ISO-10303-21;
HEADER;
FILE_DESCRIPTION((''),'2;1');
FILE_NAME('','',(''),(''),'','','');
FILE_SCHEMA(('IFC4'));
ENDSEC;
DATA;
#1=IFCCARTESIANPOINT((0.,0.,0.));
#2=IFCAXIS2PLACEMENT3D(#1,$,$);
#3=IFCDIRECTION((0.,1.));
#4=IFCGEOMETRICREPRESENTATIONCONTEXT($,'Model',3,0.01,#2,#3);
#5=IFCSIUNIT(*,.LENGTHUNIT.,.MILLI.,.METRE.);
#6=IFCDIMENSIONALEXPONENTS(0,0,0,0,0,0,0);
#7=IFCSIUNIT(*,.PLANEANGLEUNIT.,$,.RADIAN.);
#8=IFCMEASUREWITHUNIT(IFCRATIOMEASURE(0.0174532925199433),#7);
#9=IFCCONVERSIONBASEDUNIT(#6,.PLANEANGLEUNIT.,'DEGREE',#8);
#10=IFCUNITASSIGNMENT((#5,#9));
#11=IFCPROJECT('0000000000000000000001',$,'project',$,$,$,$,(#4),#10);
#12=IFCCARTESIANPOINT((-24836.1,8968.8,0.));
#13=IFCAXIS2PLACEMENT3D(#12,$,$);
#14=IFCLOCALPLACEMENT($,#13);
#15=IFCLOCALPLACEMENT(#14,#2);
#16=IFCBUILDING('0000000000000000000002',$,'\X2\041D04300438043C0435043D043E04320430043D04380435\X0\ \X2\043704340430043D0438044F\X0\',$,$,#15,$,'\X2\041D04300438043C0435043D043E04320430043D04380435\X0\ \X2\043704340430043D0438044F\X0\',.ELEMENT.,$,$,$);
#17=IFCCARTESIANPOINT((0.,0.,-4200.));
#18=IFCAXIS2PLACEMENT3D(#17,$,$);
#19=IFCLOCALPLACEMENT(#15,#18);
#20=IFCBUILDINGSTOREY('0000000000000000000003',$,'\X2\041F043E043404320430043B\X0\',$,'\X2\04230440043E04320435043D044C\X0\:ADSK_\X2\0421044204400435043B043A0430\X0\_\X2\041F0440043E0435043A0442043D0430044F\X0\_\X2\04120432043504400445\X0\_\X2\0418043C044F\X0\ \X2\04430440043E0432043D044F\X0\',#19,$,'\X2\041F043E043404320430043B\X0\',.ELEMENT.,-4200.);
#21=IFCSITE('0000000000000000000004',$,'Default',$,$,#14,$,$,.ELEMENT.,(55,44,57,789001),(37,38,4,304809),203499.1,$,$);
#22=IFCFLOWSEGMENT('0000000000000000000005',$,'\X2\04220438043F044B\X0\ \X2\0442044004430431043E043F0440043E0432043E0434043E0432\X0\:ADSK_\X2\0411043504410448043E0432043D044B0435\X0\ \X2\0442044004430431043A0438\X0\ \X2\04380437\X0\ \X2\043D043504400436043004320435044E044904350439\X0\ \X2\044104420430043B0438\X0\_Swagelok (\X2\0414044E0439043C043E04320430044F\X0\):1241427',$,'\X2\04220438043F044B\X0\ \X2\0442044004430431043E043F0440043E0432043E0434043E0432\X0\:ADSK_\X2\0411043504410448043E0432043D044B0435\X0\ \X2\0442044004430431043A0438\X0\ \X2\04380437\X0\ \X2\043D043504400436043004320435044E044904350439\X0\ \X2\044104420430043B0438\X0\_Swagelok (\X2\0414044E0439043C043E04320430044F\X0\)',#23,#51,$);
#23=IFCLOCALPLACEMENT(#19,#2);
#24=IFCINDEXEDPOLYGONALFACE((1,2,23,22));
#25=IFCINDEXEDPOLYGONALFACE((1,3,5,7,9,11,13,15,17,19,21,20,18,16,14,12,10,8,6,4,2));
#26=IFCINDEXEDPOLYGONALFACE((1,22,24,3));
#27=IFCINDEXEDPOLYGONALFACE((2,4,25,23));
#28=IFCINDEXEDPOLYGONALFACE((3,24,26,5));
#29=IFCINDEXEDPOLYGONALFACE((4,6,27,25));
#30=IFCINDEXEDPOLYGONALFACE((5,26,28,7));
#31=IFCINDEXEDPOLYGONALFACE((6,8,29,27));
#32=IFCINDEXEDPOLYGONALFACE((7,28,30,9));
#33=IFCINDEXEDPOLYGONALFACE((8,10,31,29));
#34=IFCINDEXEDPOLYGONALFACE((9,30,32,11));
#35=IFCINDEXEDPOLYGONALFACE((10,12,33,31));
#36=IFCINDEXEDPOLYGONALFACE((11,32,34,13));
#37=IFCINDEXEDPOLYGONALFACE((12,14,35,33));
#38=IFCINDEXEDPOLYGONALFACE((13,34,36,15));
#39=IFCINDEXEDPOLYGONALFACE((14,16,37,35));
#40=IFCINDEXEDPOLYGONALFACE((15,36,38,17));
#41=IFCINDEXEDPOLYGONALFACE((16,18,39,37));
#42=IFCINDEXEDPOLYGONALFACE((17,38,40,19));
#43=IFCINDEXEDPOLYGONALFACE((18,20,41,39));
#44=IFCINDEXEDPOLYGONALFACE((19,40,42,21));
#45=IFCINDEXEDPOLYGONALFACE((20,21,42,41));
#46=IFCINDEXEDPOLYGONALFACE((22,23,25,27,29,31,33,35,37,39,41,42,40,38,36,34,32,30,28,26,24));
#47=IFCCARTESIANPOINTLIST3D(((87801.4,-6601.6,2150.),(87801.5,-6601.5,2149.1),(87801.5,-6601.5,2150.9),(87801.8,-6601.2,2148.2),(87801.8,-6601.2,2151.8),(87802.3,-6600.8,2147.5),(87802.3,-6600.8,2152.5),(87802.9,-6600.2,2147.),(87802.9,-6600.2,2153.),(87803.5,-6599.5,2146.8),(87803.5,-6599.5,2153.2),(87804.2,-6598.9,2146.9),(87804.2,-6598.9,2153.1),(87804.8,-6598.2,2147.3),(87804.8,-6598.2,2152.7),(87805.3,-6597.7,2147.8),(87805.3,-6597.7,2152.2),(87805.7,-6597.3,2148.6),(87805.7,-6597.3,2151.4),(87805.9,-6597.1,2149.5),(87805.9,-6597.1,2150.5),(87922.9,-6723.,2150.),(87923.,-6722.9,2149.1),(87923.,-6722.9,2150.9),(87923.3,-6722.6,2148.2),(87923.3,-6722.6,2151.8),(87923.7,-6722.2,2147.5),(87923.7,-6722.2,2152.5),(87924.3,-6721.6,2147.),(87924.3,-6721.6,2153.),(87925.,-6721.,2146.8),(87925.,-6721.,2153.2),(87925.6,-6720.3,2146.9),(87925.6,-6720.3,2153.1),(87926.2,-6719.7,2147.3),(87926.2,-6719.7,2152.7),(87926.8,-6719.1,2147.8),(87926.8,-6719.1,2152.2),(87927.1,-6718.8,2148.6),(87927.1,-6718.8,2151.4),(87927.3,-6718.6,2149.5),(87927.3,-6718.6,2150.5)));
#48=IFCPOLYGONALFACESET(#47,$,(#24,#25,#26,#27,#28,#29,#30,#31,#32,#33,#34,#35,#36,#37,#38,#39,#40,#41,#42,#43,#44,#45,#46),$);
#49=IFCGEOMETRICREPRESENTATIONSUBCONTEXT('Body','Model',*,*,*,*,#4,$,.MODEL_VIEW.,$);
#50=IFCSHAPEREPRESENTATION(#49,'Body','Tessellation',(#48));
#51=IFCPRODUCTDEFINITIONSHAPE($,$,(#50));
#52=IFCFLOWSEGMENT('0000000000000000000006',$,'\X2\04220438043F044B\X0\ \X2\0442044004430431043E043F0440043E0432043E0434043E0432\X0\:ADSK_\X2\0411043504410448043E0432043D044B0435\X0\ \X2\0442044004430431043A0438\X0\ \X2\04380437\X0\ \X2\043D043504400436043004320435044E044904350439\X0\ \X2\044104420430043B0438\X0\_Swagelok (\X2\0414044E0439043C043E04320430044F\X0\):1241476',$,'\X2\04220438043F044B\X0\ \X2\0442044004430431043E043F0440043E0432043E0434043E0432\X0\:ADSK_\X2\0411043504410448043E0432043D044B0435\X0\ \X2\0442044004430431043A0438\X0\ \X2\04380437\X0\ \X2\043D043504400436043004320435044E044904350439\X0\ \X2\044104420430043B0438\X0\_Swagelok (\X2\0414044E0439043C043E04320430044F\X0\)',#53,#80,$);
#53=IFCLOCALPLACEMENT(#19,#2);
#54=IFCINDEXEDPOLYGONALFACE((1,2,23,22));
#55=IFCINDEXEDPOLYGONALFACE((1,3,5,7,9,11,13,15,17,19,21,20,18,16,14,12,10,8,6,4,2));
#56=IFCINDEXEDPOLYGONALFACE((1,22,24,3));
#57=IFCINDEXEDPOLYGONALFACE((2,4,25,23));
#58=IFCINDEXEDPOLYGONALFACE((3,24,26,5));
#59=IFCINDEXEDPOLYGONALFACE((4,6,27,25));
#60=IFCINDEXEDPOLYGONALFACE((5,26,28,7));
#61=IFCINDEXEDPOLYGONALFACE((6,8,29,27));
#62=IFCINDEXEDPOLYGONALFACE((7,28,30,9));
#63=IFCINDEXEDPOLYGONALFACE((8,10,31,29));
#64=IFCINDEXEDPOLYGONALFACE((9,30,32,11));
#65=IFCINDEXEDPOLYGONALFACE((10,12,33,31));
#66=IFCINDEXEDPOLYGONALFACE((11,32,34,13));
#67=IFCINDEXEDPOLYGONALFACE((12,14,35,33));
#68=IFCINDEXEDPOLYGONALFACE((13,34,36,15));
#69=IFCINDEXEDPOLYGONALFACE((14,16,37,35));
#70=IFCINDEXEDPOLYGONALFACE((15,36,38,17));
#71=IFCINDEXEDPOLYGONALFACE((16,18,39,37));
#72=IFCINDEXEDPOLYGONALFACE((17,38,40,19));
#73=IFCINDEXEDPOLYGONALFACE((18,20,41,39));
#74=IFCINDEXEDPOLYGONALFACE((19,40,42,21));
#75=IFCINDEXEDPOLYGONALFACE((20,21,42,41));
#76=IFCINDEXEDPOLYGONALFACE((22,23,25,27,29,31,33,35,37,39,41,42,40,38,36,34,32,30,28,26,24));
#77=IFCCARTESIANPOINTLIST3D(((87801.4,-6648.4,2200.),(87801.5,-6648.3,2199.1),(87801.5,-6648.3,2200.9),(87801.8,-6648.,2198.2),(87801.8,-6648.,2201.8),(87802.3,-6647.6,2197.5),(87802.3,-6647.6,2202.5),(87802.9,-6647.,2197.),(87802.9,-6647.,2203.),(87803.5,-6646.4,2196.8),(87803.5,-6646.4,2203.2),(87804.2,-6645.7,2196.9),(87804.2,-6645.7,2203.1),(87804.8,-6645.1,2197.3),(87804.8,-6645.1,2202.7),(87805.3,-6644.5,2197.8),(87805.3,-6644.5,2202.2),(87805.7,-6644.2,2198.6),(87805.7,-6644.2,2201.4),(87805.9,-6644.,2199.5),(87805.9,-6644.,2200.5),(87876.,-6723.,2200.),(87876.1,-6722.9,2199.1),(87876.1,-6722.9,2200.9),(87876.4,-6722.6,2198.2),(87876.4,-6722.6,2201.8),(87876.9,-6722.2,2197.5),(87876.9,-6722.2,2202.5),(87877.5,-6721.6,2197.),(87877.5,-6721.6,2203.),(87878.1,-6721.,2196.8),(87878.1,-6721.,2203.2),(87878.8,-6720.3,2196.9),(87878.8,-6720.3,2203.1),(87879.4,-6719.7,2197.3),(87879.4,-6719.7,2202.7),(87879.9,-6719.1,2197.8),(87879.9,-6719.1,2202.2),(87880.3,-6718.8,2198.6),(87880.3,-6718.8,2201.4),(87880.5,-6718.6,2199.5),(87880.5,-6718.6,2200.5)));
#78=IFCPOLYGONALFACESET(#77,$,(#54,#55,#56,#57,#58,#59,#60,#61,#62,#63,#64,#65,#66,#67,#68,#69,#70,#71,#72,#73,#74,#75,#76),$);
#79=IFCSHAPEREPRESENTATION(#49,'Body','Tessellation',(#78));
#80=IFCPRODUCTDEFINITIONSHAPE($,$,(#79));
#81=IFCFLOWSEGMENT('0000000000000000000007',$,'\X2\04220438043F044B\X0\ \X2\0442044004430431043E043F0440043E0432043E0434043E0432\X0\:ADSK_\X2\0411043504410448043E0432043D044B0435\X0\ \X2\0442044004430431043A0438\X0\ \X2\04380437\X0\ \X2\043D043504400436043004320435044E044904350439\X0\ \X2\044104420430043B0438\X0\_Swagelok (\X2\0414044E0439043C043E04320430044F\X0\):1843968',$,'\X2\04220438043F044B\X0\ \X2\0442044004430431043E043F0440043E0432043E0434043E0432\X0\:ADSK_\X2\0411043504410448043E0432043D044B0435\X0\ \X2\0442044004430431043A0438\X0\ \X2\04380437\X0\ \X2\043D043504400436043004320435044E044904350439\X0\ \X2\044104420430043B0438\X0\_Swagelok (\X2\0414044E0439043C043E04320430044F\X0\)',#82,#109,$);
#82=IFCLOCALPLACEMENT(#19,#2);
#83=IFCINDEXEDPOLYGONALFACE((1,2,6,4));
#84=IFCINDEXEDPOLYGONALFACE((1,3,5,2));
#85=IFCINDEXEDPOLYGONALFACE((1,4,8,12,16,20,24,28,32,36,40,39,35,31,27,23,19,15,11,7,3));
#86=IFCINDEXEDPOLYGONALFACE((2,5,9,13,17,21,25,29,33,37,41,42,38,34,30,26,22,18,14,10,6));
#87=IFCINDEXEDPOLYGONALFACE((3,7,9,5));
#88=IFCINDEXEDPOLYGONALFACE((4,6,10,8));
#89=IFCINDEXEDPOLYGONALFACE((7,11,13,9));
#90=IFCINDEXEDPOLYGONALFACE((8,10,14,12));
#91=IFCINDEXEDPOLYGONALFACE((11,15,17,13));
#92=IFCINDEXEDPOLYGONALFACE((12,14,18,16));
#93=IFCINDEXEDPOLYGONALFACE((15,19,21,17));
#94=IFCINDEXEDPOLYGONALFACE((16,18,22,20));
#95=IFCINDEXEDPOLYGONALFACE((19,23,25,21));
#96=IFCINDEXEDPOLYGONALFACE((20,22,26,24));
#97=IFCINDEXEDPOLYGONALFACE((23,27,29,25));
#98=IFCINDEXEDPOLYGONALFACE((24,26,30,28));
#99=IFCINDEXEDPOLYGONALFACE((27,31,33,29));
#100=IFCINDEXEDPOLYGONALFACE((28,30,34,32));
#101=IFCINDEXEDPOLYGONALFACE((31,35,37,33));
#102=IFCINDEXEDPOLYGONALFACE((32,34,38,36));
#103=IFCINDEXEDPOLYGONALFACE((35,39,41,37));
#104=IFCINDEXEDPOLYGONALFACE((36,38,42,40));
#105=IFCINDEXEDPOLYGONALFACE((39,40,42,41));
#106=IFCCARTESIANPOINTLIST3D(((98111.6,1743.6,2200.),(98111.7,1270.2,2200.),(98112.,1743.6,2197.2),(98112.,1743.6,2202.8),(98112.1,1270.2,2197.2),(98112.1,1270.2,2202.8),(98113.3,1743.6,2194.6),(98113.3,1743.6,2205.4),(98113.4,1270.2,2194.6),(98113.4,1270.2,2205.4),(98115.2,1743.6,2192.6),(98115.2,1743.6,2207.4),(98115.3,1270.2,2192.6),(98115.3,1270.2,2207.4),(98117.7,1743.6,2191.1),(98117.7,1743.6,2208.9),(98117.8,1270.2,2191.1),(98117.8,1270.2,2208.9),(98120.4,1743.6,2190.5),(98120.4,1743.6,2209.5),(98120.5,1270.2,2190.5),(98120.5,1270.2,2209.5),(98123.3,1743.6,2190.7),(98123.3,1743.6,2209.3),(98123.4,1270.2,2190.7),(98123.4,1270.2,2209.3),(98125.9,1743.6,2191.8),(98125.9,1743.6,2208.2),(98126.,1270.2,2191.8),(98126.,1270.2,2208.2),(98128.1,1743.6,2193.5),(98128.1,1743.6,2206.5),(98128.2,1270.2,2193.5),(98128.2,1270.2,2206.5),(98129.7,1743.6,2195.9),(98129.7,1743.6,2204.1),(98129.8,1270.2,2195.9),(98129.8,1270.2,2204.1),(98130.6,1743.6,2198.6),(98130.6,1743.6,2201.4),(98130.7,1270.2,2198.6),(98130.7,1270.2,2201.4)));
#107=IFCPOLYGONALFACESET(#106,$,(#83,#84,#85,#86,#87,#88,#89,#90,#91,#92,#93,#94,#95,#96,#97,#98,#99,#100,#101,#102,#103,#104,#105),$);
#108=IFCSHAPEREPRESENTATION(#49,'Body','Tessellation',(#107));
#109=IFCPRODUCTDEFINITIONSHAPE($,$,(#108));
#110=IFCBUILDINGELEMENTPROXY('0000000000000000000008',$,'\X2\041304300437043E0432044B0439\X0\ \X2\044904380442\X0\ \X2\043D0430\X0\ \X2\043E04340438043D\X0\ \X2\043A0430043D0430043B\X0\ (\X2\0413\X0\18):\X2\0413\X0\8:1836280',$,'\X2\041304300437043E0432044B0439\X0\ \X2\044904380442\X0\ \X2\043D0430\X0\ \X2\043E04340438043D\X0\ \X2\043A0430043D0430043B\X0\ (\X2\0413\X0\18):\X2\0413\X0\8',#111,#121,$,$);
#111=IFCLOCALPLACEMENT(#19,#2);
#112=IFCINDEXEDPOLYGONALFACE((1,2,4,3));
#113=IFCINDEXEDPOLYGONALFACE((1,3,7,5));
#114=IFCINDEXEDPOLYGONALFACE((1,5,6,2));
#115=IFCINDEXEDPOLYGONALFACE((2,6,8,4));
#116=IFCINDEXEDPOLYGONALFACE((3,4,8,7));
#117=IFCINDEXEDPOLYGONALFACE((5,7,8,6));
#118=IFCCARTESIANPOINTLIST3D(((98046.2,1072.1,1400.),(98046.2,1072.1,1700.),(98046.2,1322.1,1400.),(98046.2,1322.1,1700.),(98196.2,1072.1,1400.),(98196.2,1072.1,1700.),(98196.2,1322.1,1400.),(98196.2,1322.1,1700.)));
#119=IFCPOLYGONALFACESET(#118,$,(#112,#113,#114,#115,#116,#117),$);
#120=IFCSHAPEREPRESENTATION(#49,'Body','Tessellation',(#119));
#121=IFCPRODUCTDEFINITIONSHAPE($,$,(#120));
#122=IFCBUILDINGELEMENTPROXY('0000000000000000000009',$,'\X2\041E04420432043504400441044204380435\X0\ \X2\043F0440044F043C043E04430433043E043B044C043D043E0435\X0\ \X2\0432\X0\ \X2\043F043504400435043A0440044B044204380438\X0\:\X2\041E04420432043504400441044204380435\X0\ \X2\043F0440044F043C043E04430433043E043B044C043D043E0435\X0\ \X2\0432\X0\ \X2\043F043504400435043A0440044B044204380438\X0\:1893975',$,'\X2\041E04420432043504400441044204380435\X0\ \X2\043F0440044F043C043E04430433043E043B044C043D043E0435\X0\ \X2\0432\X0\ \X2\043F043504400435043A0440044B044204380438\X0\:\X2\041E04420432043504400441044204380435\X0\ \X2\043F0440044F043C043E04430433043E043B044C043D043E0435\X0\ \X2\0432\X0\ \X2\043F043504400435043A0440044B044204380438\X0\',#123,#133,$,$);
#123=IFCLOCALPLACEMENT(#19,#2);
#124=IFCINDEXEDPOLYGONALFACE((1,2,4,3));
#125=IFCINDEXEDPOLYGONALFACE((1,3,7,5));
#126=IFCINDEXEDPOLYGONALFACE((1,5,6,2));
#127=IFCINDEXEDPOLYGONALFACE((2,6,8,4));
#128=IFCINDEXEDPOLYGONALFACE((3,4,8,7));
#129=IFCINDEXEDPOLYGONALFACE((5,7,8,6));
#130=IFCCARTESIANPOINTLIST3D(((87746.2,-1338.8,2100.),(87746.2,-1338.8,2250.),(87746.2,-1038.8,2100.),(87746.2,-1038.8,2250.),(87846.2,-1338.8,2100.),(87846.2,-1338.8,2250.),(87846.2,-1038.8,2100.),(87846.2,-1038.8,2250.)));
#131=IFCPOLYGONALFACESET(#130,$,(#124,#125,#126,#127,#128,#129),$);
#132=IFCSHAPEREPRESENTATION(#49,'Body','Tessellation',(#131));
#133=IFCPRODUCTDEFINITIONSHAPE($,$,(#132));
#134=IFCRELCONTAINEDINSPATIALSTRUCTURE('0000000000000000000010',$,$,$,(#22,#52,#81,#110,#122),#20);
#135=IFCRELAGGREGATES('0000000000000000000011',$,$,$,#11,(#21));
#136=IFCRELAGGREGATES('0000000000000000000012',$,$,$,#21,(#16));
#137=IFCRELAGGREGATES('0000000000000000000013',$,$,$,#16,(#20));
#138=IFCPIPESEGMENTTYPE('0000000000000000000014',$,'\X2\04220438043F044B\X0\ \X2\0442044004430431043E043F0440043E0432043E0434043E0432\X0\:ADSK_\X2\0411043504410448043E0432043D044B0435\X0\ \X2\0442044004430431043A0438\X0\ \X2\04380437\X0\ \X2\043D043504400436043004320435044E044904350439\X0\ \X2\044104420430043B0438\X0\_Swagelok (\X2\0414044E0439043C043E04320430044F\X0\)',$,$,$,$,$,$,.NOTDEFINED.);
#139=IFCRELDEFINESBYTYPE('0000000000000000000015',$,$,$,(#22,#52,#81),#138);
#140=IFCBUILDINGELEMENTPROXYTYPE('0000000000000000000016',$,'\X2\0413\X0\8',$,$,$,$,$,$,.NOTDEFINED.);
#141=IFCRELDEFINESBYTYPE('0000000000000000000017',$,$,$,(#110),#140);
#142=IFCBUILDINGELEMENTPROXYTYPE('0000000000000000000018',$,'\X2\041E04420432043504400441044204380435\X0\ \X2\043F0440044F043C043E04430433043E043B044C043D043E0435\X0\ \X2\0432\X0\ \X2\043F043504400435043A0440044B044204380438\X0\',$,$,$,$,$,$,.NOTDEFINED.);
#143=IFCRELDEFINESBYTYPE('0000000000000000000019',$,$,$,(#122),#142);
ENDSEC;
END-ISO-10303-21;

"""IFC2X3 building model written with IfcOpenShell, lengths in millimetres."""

from ifc_helpers import new_model, entity, si_unit, converted_unit, direction, frame, origin, origin_2d_with_axis, place, context, subcontext, project, spatial, rectangle, circle, extrude, type_object, element, save


model = new_model("IFC2X3")

# Units and contexts
model_context = context("Model", 3, precision=0.01, world=origin(), true_north=direction((0.0, 1.0)))
body_context = subcontext(model_context, "Body", "Model", "MODEL_VIEW")
ifc_project = project(units=[si_unit("LENGTHUNIT", "METRE", prefix="MILLI"), converted_unit("PLANEANGLEUNIT", "DEGREE", entity("IfcRatioMeasure", 0.0174532925199433), si_unit("PLANEANGLEUNIT", "RADIAN"), dimensions=[0, 0, 0, 0, 0, 0, 0])], contexts=[model_context])

# Site, building, storey
site_placement = place(None, frame((-24836.1, 8968.8, 0.0)))
site = spatial("IfcSite", under=ifc_project, at=site_placement, Name="Default", CompositionType="ELEMENT", RefLatitude=(55, 44, 57, 789001), RefLongitude=(37, 38, 4, 304809), RefElevation=203499.1)
building_placement = place(site_placement, origin())
building = spatial("IfcBuilding", under=site, at=building_placement, Name="Наименование здания", LongName="Наименование здания", CompositionType="ELEMENT")
storey_placement = place(building_placement, frame((0.0, 0.0, -4200.0)))
storey = spatial("IfcBuildingStorey", under=building, at=storey_placement, Name="Подвал", ObjectType="Уровень:ADSK_Стрелка_Проектная_Вверх_Имя уровня", LongName="Подвал", CompositionType="ELEMENT", Elevation=-4200.0)

# Flow segments
pipe_segment_type_1 = type_object("IfcPipeSegmentType", Name="Типы трубопроводов:ADSK_Бесшовные трубки из нержавеющей стали_Swagelok (Дюймовая)", PredefinedType="NOTDEFINED")
flow_segment_1_placement = place(storey_placement, frame((87799.9, -6724.6, 2145.2)))
element("IfcFlowSegment", 1, at=flow_segment_1_placement, inside=storey, type_object=pipe_segment_type_1, Name="Типы трубопроводов:ADSK_Бесшовные трубки из нержавеющей стали_Swagelok (Дюймовая):1241427", ObjectType="Типы трубопроводов:ADSK_Бесшовные трубки из нержавеющей стали_Swagelok (Дюймовая)", context=body_context, shape_type="SweptSolid", body=[
    extrude(circle(Radius=3.2, at=origin_2d_with_axis()), frame((125.3, 3.8, 4.8), z_axis=(-0.707107, 0.707107, 0.0), x_axis=(-0.707107, -0.707107, 0.0)), (0.0, 0.0, 1.0), 171.7),
])
flow_segment_2_placement = place(storey_placement, frame((87799.9, -6724.6, 2195.2)))
element("IfcFlowSegment", 2, at=flow_segment_2_placement, inside=storey, type_object=pipe_segment_type_1, Name="Типы трубопроводов:ADSK_Бесшовные трубки из нержавеющей стали_Swagelok (Дюймовая):1241476", ObjectType="Типы трубопроводов:ADSK_Бесшовные трубки из нержавеющей стали_Swagelok (Дюймовая)", context=body_context, shape_type="SweptSolid", body=[
    extrude(circle(Radius=3.2, at=origin_2d_with_axis()), frame((3.8, 78.4, 4.8), z_axis=(0.707107, -0.707107, 0.0), x_axis=(-0.707107, -0.707107, 0.0)), (0.0, 0.0, 1.0), 105.5),
])
flow_segment_3_placement = place(storey_placement, frame((98110.0, 1270.2, 2188.9)))
element("IfcFlowSegment", 3, at=flow_segment_3_placement, inside=storey, type_object=pipe_segment_type_1, Name="Типы трубопроводов:ADSK_Бесшовные трубки из нержавеющей стали_Swagelok (Дюймовая):1843968", ObjectType="Типы трубопроводов:ADSK_Бесшовные трубки из нержавеющей стали_Swagelok (Дюймовая)", context=body_context, shape_type="SweptSolid", body=[
    extrude(circle(Radius=9.5, at=origin_2d_with_axis()), frame((11.1, 473.4, 11.1), z_axis=(0.000218, -1.0, 0.0), x_axis=(-1.0, -0.000218, 0.0)), (0.0, 0.0, 1.0), 473.3),
])

# Building element proxies
building_element_proxy_type_1 = type_object("IfcBuildingElementProxyType", Name="Г8", PredefinedType="NOTDEFINED")
proxy_1_placement = place(storey_placement, frame((98046.2, 1072.1, 1400.0)))
element("IfcBuildingElementProxy", 4, at=proxy_1_placement, inside=storey, type_object=building_element_proxy_type_1, Name="Газовый щит на один канал (Г18):Г8:1836280", ObjectType="Газовый щит на один канал (Г18):Г8", context=body_context, shape_type="SweptSolid", body=[
    extrude(rectangle(XDim=150.0, YDim=250.0, at=origin_2d_with_axis()), frame((75.0, 125.0, 0.0)), (0.0, 0.0, 1.0), 300.0),
])
building_element_proxy_type_2 = type_object("IfcBuildingElementProxyType", Name="Отверстие прямоугольное в перекрытии", PredefinedType="NOTDEFINED")
proxy_2_placement = place(storey_placement, frame((87746.2, -1338.8, 2100.0)))
element("IfcBuildingElementProxy", 5, at=proxy_2_placement, inside=storey, type_object=building_element_proxy_type_2, Name="Отверстие прямоугольное в перекрытии:Отверстие прямоугольное в перекрытии:1893975", ObjectType="Отверстие прямоугольное в перекрытии:Отверстие прямоугольное в перекрытии", context=body_context, shape_type="SweptSolid", body=[
    extrude(rectangle(XDim=300.0, YDim=100.0, at=origin_2d_with_axis()), frame((50.0, 150.0, 0.0), z_axis=(0.0, 0.0, 1.0), x_axis=(0.0, -1.0, 0.0)), (0.0, 0.0, 1.0), 150.0),
])

save(model, "model.ifc")
